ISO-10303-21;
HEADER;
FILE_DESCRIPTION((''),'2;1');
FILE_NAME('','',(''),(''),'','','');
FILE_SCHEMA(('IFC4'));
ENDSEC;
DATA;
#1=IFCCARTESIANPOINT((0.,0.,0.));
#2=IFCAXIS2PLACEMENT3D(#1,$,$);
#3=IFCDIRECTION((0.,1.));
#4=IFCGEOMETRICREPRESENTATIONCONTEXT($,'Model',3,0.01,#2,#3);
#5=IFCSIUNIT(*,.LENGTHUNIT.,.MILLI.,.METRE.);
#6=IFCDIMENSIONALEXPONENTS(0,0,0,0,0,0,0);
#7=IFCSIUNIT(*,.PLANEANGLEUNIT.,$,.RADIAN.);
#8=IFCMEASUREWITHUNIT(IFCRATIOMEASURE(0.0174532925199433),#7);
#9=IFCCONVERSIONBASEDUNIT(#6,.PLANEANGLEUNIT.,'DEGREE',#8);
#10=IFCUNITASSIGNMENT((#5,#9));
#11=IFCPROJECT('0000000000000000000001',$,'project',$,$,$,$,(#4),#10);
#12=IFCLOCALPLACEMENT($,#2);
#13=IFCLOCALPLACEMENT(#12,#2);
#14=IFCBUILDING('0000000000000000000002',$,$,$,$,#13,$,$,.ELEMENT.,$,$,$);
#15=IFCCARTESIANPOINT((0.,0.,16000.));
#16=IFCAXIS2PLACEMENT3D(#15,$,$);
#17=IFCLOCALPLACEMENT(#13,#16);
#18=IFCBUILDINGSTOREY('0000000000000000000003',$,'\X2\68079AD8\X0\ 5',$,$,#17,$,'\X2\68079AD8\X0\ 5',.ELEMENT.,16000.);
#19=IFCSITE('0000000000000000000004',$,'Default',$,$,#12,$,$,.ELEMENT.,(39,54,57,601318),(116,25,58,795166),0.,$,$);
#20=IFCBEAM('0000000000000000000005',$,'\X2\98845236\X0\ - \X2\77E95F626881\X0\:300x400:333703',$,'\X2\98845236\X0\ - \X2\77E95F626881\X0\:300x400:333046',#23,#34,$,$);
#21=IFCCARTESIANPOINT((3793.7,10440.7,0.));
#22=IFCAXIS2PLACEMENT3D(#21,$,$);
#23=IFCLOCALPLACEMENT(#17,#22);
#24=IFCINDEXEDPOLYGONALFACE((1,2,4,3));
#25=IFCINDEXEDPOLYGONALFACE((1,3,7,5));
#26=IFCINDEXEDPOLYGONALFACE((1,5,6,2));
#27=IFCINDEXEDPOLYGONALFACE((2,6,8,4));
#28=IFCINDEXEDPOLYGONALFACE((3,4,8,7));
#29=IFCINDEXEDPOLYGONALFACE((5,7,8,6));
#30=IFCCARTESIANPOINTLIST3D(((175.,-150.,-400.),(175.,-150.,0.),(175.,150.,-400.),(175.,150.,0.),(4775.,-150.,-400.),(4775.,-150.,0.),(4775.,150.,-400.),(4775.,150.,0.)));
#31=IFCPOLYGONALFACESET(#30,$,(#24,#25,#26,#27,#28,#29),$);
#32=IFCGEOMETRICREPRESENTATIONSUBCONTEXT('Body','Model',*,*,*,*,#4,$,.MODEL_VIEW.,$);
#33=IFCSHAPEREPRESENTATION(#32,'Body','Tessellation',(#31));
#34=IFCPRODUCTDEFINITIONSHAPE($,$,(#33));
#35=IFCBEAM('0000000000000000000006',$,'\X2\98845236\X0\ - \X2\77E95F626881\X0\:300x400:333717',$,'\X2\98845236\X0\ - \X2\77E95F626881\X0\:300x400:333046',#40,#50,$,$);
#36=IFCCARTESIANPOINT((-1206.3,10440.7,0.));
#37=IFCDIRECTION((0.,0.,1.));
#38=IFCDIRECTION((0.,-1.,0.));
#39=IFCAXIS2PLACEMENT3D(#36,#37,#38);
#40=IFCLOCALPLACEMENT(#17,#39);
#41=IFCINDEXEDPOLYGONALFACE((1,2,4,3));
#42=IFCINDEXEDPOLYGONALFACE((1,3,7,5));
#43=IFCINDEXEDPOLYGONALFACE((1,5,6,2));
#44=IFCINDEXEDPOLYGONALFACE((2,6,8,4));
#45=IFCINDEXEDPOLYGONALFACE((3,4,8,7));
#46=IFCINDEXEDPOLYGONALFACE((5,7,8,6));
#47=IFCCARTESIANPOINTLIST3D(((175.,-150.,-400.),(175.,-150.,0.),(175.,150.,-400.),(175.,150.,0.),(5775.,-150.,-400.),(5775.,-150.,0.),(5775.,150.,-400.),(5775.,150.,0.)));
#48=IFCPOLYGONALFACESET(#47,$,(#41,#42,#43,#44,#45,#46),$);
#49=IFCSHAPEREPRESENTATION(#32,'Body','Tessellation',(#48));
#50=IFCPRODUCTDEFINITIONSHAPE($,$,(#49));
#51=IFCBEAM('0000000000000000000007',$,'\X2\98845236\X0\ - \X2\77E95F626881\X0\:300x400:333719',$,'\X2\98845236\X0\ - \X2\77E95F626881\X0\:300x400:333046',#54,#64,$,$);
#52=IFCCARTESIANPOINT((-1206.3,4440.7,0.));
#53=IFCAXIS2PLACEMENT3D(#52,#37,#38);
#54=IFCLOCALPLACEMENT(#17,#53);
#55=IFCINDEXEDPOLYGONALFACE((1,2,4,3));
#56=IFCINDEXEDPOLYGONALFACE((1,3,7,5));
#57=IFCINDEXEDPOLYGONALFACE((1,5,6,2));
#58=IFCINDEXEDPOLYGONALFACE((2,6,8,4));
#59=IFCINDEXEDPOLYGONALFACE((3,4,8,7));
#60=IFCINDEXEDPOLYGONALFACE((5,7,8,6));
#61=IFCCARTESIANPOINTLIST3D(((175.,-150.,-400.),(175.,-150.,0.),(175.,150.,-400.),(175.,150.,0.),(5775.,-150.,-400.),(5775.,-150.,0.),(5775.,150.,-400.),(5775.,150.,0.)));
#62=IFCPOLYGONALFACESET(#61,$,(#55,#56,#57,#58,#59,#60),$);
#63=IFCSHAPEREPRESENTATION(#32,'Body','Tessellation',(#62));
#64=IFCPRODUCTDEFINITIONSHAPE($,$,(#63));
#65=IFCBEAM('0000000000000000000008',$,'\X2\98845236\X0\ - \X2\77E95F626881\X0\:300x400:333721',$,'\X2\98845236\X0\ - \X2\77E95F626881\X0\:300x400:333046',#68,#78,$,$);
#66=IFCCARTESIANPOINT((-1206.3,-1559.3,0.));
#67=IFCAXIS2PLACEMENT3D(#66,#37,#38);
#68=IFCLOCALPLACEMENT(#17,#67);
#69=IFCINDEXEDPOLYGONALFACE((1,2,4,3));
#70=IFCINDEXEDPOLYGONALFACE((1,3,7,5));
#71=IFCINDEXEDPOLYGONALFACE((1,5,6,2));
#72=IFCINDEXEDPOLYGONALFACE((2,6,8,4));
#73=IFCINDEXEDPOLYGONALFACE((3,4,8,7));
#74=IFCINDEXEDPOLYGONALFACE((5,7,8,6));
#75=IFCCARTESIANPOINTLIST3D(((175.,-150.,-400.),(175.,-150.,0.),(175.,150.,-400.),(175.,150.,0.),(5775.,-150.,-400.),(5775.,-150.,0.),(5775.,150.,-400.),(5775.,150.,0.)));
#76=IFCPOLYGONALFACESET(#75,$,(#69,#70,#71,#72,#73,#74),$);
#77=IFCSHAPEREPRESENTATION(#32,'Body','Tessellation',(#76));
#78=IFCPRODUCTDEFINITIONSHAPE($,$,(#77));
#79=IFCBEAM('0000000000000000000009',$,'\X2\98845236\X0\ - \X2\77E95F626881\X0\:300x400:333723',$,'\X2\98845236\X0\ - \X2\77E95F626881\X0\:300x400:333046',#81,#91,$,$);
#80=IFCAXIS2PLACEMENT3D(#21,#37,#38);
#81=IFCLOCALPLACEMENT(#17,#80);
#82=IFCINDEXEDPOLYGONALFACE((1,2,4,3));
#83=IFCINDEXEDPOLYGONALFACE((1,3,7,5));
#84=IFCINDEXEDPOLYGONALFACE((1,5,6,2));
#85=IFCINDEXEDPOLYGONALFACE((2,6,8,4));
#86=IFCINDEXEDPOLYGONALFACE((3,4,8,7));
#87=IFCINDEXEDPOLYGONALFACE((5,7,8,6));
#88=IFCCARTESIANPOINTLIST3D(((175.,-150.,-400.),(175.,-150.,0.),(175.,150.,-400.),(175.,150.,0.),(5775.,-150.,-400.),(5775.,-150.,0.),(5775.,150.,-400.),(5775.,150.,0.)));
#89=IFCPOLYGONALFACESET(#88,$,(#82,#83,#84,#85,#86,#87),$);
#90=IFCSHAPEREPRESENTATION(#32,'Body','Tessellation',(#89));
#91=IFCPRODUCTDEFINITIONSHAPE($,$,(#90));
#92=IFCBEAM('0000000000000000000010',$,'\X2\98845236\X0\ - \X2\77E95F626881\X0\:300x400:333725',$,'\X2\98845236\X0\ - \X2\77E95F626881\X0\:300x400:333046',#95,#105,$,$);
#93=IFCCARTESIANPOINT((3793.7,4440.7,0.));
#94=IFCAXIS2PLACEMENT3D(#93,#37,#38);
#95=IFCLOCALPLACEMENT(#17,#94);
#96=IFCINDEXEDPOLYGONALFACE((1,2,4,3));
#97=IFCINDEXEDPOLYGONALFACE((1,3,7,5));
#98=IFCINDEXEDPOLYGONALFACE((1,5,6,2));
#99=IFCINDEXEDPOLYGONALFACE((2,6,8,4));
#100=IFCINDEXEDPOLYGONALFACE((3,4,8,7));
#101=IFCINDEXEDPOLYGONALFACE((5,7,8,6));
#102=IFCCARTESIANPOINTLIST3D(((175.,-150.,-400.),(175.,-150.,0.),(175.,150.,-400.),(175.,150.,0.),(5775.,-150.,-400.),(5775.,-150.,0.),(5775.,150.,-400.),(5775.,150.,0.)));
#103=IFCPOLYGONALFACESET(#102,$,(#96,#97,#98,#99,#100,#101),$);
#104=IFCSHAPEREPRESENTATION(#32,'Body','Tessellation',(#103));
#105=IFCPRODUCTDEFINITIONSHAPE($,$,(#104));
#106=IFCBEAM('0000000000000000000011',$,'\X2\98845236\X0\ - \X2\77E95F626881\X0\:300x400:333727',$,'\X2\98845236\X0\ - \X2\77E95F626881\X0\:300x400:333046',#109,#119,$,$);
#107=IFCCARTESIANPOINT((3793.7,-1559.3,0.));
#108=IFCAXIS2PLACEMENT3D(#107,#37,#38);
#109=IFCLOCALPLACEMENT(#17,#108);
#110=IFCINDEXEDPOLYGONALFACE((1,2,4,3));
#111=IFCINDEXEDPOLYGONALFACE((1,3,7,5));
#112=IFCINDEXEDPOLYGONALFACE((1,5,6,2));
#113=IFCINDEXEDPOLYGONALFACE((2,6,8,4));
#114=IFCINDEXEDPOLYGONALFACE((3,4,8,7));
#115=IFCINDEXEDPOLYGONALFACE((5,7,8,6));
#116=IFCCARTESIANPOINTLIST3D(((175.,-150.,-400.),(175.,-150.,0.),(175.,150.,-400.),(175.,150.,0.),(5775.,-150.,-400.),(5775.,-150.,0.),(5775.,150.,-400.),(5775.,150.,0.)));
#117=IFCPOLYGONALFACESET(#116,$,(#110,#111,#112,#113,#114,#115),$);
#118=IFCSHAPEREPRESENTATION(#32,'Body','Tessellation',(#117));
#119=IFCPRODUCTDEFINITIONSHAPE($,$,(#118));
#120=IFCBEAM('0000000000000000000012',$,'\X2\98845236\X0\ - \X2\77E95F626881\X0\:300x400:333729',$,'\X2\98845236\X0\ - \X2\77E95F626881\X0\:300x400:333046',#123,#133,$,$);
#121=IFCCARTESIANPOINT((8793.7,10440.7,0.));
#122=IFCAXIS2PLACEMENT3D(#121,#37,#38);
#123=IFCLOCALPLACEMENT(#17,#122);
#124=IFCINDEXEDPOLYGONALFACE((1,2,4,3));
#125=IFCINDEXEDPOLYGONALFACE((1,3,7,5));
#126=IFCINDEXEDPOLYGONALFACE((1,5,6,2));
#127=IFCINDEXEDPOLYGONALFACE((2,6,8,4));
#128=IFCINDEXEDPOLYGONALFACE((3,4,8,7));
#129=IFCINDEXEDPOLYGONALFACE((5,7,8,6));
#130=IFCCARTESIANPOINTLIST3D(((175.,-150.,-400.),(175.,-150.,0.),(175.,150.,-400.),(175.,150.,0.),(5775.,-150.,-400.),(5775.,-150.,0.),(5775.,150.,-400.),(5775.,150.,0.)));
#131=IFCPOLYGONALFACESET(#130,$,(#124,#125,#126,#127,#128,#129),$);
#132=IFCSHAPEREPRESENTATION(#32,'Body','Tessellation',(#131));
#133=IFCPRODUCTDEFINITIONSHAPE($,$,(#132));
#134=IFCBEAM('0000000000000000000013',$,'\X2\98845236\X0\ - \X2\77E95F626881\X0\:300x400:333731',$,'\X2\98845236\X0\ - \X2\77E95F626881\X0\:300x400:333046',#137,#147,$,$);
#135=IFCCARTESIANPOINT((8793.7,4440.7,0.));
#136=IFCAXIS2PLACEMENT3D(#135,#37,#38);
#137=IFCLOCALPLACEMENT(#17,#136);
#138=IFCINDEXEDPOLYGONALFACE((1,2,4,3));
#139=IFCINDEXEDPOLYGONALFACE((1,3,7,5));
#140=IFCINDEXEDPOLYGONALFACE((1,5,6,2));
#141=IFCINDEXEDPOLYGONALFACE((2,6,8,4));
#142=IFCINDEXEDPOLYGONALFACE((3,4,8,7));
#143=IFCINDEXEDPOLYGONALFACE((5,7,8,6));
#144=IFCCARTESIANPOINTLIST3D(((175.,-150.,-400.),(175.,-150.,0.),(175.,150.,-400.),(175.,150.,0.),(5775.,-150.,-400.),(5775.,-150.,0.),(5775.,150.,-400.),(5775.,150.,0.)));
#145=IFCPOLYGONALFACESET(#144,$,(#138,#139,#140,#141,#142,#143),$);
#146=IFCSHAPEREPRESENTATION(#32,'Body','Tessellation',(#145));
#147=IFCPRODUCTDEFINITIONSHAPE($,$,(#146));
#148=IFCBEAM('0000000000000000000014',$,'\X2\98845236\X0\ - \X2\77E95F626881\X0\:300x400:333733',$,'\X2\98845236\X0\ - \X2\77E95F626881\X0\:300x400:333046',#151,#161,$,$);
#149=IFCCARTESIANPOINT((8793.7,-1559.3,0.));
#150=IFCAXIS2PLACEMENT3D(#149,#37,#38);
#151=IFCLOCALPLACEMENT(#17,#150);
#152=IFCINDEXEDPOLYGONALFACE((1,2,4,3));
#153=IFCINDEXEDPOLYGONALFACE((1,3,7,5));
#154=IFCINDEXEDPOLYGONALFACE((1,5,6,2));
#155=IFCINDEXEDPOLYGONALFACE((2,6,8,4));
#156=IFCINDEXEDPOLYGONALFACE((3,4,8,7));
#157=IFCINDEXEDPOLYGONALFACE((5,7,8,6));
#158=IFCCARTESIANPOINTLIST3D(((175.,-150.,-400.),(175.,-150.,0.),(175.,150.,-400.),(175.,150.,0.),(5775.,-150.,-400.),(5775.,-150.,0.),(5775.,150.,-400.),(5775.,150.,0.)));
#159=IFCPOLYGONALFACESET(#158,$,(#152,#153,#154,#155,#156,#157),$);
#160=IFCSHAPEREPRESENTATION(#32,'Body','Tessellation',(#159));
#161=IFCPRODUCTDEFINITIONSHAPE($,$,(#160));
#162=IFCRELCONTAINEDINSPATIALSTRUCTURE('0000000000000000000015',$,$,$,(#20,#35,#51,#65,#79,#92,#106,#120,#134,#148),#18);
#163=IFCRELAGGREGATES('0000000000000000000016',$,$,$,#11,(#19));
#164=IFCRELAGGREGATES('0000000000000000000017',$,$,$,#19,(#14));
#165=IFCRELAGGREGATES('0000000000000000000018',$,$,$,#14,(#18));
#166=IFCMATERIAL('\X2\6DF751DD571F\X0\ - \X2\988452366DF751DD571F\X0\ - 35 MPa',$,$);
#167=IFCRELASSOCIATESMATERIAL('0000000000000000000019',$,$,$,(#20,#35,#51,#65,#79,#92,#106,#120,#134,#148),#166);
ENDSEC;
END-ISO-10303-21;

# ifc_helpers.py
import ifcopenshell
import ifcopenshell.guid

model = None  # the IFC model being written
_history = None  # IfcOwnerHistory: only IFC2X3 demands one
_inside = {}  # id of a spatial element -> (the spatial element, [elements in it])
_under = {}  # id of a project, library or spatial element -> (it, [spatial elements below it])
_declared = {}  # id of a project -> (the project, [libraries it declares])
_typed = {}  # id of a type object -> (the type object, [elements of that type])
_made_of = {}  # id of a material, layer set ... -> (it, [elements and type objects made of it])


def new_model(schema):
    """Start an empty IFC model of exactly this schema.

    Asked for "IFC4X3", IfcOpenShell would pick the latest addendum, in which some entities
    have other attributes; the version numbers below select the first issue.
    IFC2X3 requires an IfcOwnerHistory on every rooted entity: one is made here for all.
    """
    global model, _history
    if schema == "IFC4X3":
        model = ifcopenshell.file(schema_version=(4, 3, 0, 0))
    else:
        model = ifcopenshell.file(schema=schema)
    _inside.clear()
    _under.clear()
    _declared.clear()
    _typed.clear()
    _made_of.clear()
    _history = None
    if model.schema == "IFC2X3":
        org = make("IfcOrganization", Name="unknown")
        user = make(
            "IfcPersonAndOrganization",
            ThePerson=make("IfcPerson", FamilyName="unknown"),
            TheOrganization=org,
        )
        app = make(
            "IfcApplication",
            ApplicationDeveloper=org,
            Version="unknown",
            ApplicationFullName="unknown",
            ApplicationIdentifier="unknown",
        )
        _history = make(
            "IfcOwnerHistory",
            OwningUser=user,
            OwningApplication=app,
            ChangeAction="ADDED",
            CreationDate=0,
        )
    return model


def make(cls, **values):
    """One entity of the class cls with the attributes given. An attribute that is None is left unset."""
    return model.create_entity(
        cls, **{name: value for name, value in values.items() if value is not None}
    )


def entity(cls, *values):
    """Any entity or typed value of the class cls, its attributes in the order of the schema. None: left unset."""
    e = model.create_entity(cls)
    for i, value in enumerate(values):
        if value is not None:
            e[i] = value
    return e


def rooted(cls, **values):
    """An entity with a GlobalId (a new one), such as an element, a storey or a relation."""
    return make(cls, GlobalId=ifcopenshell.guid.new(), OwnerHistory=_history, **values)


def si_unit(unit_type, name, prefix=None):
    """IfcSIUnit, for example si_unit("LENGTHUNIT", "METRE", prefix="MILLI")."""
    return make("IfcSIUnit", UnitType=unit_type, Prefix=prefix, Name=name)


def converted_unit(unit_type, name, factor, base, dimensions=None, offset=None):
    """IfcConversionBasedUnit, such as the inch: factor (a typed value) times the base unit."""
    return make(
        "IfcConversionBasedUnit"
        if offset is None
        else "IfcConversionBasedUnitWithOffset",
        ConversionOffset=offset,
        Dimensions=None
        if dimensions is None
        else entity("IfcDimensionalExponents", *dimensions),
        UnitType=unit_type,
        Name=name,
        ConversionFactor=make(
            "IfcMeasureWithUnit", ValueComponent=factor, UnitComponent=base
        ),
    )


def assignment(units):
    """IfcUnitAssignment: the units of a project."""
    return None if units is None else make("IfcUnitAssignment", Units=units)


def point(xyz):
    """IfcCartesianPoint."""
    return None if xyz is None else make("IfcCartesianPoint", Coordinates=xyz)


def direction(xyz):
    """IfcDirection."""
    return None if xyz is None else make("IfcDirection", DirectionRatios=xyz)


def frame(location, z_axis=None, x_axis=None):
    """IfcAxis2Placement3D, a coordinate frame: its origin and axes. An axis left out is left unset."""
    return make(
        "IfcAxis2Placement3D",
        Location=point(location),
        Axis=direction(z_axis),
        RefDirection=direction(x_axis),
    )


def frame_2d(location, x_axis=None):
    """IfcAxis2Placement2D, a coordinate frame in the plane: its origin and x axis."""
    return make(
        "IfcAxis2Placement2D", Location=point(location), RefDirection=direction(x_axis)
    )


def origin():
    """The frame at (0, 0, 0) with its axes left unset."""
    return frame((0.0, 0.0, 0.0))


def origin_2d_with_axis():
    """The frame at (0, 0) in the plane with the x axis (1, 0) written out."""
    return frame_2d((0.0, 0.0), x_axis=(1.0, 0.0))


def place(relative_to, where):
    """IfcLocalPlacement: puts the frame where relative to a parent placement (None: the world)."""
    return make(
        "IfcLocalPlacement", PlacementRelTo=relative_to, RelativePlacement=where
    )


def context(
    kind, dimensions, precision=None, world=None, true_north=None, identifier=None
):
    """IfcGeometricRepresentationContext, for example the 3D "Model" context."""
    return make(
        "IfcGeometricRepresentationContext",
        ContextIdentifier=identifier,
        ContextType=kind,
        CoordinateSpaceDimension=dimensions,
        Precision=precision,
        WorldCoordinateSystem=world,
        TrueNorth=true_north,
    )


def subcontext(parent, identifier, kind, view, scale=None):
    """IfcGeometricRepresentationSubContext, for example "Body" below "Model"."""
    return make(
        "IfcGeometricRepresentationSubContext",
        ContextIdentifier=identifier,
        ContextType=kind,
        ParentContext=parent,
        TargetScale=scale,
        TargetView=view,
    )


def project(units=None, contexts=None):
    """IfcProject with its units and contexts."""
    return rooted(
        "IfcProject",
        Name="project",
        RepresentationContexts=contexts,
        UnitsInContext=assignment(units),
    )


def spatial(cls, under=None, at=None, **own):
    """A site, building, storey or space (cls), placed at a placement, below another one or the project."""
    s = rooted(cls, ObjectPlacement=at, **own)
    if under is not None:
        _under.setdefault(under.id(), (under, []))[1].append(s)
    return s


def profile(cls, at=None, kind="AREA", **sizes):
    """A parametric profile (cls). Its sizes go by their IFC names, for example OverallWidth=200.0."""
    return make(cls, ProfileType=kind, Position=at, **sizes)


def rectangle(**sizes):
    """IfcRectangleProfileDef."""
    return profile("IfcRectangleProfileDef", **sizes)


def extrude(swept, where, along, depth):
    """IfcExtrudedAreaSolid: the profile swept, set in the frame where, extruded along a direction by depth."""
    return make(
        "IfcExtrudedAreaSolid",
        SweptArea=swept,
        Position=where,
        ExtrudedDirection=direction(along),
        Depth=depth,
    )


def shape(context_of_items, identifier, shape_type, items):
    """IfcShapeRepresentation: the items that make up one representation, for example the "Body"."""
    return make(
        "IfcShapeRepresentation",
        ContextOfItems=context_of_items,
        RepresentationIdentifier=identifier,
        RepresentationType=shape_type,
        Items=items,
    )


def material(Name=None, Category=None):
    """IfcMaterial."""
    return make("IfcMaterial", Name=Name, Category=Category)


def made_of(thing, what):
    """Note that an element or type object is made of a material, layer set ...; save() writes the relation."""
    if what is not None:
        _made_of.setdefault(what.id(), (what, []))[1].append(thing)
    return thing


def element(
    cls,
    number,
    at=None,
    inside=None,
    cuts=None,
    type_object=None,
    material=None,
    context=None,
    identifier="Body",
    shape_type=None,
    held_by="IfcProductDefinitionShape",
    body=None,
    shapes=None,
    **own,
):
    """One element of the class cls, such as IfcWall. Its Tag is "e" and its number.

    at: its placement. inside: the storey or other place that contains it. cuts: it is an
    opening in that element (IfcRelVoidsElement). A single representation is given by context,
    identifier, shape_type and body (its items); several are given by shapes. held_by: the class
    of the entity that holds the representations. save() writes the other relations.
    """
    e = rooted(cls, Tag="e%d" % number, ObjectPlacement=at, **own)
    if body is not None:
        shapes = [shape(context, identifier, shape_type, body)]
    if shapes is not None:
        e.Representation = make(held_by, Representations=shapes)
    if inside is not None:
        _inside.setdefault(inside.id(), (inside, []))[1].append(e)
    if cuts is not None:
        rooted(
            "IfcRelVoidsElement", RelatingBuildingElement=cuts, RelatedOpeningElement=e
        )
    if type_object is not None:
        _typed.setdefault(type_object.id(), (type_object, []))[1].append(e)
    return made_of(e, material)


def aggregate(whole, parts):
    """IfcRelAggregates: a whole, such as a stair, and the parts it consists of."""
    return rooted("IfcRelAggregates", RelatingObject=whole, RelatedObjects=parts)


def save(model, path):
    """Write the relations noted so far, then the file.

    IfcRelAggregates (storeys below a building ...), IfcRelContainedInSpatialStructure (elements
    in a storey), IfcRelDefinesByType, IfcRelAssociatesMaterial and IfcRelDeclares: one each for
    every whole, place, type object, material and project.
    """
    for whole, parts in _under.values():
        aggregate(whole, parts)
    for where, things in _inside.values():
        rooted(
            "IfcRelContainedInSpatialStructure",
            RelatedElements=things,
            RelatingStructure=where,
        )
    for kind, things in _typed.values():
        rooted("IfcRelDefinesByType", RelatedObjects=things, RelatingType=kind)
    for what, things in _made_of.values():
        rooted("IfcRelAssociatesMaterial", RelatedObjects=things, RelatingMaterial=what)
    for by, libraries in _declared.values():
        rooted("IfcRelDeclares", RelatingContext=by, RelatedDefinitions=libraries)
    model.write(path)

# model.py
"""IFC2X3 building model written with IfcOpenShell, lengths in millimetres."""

from ifc_helpers import new_model, entity, si_unit, converted_unit, direction, frame, frame_2d, origin, origin_2d_with_axis, place, context, subcontext, project, spatial, rectangle, extrude, material, element, save


model = new_model("IFC2X3")

# Units and contexts
model_context = context("Model", 3, precision=0.01, world=origin(), true_north=direction((0.0, 1.0)))
body_context = subcontext(model_context, "Body", "Model", "MODEL_VIEW")
ifc_project = project(units=[si_unit("LENGTHUNIT", "METRE", prefix="MILLI"), converted_unit("PLANEANGLEUNIT", "DEGREE", entity("IfcRatioMeasure", 0.0174532925199433), si_unit("PLANEANGLEUNIT", "RADIAN"), dimensions=[0, 0, 0, 0, 0, 0, 0])], contexts=[model_context])

# Site, building, storey
site_placement = place(None, origin())
site = spatial("IfcSite", under=ifc_project, at=site_placement, Name="Default", CompositionType="ELEMENT", RefLatitude=(39, 54, 57, 601318), RefLongitude=(116, 25, 58, 795166), RefElevation=0.0)
building_placement = place(site_placement, origin())
building = spatial("IfcBuilding", under=site, at=building_placement, CompositionType="ELEMENT")
storey_placement = place(building_placement, frame((0.0, 0.0, 16000.0)))
storey = spatial("IfcBuildingStorey", under=building, at=storey_placement, Name="标高 5", LongName="标高 5", CompositionType="ELEMENT", Elevation=16000.0)

# Shared definitions
ifc_material_1 = material(Name="混凝土 - 预制混凝土 - 35 MPa")

# Beams
beam_1_placement = place(storey_placement, frame((3793.7, 10440.7, 0.0)))
element("IfcBeam", 1, at=beam_1_placement, inside=storey, material=ifc_material_1, Name="预制 - 矩形梁:300x400:333703", ObjectType="预制 - 矩形梁:300x400:333046", context=body_context, shape_type="SweptSolid", body=[
    extrude(rectangle(XDim=400.0, YDim=300.0, at=frame_2d((0.0, 0.0), x_axis=(1.0, 0.0))), frame((175.0, 0.0, -200.0), z_axis=(1.0, 0.0, 0.0), x_axis=(0.0, 0.0, -1.0)), (0.0, 0.0, 1.0), 4600.0),
])
beam_2_placement = place(storey_placement, frame((-1206.3, 10440.7, 0.0), z_axis=(0.0, 0.0, 1.0), x_axis=(0.0, -1.0, 0.0)))
element("IfcBeam", 2, at=beam_2_placement, inside=storey, material=ifc_material_1, Name="预制 - 矩形梁:300x400:333717", ObjectType="预制 - 矩形梁:300x400:333046", context=body_context, shape_type="SweptSolid", body=[
    extrude(rectangle(XDim=400.0, YDim=300.0, at=frame_2d((0.0, 0.0), x_axis=(1.0, 0.0))), frame((175.0, 0.0, -200.0), z_axis=(1.0, 0.0, 0.0), x_axis=(0.0, 0.0, -1.0)), (0.0, 0.0, 1.0), 5600.0),
])
beam_3_placement = place(storey_placement, frame((-1206.3, 4440.7, 0.0), z_axis=(0.0, 0.0, 1.0), x_axis=(0.0, -1.0, 0.0)))
element("IfcBeam", 3, at=beam_3_placement, inside=storey, material=ifc_material_1, Name="预制 - 矩形梁:300x400:333719", ObjectType="预制 - 矩形梁:300x400:333046", context=body_context, shape_type="SweptSolid", body=[
    extrude(rectangle(XDim=400.0, YDim=300.0, at=frame_2d((0.0, 0.0), x_axis=(1.0, 0.0))), frame((175.0, 0.0, -200.0), z_axis=(1.0, 0.0, 0.0), x_axis=(0.0, 0.0, -1.0)), (0.0, 0.0, 1.0), 5600.0),
])
beam_4_placement = place(storey_placement, frame((-1206.3, -1559.3, 0.0), z_axis=(0.0, 0.0, 1.0), x_axis=(0.0, -1.0, 0.0)))
element("IfcBeam", 4, at=beam_4_placement, inside=storey, material=ifc_material_1, Name="预制 - 矩形梁:300x400:333721", ObjectType="预制 - 矩形梁:300x400:333046", context=body_context, shape_type="SweptSolid", body=[
    extrude(rectangle(XDim=400.0, YDim=300.0, at=frame_2d((0.0, 0.0), x_axis=(1.0, 0.0))), frame((175.0, 0.0, -200.0), z_axis=(1.0, 0.0, 0.0), x_axis=(0.0, 0.0, -1.0)), (0.0, 0.0, 1.0), 5600.0),
])
beam_5_placement = place(storey_placement, frame((3793.7, 10440.7, 0.0), z_axis=(0.0, 0.0, 1.0), x_axis=(0.0, -1.0, 0.0)))
element("IfcBeam", 5, at=beam_5_placement, inside=storey, material=ifc_material_1, Name="预制 - 矩形梁:300x400:333723", ObjectType="预制 - 矩形梁:300x400:333046", context=body_context, shape_type="SweptSolid", body=[
    extrude(rectangle(XDim=400.0, YDim=300.0, at=frame_2d((0.0, 0.0), x_axis=(1.0, 0.0))), frame((175.0, 0.0, -200.0), z_axis=(1.0, 0.0, 0.0), x_axis=(0.0, 0.0, -1.0)), (0.0, 0.0, 1.0), 5600.0),
])
beam_6_placement = place(storey_placement, frame((3793.7, 4440.7, 0.0), z_axis=(0.0, 0.0, 1.0), x_axis=(0.0, -1.0, 0.0)))
element("IfcBeam", 6, at=beam_6_placement, inside=storey, material=ifc_material_1, Name="预制 - 矩形梁:300x400:333725", ObjectType="预制 - 矩形梁:300x400:333046", context=body_context, shape_type="SweptSolid", body=[
    extrude(rectangle(XDim=400.0, YDim=300.0, at=origin_2d_with_axis()), frame((175.0, 0.0, -200.0), z_axis=(1.0, 0.0, 0.0), x_axis=(0.0, 0.0, -1.0)), (0.0, 0.0, 1.0), 5600.0),
])
beam_7_placement = place(storey_placement, frame((3793.7, -1559.3, 0.0), z_axis=(0.0, 0.0, 1.0), x_axis=(0.0, -1.0, 0.0)))
element("IfcBeam", 7, at=beam_7_placement, inside=storey, material=ifc_material_1, Name="预制 - 矩形梁:300x400:333727", ObjectType="预制 - 矩形梁:300x400:333046", context=body_context, shape_type="SweptSolid", body=[
    extrude(rectangle(XDim=400.0, YDim=300.0, at=frame_2d((0.0, 0.0), x_axis=(1.0, 0.0))), frame((175.0, 0.0, -200.0), z_axis=(1.0, 0.0, 0.0), x_axis=(0.0, 0.0, -1.0)), (0.0, 0.0, 1.0), 5600.0),
])
for number, where, z_axis, x_axis, name in (
    (8, (8793.7, 10440.7, 0.0), (0.0, 0.0, 1.0), (0.0, -1.0, 0.0), "预制 - 矩形梁:300x400:333729"),
    (9, (8793.7, 4440.7, 0.0), (0.0, 0.0, 1.0), (0.0, -1.0, 0.0), "预制 - 矩形梁:300x400:333731"),
    (10, (8793.7, -1559.3, 0.0), (0.0, 0.0, 1.0), (0.0, -1.0, 0.0), "预制 - 矩形梁:300x400:333733"),
):
    element("IfcBeam", number, at=place(storey_placement, frame(where, z_axis=z_axis, x_axis=x_axis)), inside=storey, material=ifc_material_1, Name=name, ObjectType="预制 - 矩形梁:300x400:333046", context=body_context, shape_type="SweptSolid", body=[
        extrude(rectangle(XDim=400.0, YDim=300.0, at=origin_2d_with_axis()), frame((175.0, 0.0, -200.0), z_axis=(1.0, 0.0, 0.0), x_axis=(0.0, 0.0, -1.0)), (0.0, 0.0, 1.0), 5600.0),
    ])

save(model, "model.ifc")
